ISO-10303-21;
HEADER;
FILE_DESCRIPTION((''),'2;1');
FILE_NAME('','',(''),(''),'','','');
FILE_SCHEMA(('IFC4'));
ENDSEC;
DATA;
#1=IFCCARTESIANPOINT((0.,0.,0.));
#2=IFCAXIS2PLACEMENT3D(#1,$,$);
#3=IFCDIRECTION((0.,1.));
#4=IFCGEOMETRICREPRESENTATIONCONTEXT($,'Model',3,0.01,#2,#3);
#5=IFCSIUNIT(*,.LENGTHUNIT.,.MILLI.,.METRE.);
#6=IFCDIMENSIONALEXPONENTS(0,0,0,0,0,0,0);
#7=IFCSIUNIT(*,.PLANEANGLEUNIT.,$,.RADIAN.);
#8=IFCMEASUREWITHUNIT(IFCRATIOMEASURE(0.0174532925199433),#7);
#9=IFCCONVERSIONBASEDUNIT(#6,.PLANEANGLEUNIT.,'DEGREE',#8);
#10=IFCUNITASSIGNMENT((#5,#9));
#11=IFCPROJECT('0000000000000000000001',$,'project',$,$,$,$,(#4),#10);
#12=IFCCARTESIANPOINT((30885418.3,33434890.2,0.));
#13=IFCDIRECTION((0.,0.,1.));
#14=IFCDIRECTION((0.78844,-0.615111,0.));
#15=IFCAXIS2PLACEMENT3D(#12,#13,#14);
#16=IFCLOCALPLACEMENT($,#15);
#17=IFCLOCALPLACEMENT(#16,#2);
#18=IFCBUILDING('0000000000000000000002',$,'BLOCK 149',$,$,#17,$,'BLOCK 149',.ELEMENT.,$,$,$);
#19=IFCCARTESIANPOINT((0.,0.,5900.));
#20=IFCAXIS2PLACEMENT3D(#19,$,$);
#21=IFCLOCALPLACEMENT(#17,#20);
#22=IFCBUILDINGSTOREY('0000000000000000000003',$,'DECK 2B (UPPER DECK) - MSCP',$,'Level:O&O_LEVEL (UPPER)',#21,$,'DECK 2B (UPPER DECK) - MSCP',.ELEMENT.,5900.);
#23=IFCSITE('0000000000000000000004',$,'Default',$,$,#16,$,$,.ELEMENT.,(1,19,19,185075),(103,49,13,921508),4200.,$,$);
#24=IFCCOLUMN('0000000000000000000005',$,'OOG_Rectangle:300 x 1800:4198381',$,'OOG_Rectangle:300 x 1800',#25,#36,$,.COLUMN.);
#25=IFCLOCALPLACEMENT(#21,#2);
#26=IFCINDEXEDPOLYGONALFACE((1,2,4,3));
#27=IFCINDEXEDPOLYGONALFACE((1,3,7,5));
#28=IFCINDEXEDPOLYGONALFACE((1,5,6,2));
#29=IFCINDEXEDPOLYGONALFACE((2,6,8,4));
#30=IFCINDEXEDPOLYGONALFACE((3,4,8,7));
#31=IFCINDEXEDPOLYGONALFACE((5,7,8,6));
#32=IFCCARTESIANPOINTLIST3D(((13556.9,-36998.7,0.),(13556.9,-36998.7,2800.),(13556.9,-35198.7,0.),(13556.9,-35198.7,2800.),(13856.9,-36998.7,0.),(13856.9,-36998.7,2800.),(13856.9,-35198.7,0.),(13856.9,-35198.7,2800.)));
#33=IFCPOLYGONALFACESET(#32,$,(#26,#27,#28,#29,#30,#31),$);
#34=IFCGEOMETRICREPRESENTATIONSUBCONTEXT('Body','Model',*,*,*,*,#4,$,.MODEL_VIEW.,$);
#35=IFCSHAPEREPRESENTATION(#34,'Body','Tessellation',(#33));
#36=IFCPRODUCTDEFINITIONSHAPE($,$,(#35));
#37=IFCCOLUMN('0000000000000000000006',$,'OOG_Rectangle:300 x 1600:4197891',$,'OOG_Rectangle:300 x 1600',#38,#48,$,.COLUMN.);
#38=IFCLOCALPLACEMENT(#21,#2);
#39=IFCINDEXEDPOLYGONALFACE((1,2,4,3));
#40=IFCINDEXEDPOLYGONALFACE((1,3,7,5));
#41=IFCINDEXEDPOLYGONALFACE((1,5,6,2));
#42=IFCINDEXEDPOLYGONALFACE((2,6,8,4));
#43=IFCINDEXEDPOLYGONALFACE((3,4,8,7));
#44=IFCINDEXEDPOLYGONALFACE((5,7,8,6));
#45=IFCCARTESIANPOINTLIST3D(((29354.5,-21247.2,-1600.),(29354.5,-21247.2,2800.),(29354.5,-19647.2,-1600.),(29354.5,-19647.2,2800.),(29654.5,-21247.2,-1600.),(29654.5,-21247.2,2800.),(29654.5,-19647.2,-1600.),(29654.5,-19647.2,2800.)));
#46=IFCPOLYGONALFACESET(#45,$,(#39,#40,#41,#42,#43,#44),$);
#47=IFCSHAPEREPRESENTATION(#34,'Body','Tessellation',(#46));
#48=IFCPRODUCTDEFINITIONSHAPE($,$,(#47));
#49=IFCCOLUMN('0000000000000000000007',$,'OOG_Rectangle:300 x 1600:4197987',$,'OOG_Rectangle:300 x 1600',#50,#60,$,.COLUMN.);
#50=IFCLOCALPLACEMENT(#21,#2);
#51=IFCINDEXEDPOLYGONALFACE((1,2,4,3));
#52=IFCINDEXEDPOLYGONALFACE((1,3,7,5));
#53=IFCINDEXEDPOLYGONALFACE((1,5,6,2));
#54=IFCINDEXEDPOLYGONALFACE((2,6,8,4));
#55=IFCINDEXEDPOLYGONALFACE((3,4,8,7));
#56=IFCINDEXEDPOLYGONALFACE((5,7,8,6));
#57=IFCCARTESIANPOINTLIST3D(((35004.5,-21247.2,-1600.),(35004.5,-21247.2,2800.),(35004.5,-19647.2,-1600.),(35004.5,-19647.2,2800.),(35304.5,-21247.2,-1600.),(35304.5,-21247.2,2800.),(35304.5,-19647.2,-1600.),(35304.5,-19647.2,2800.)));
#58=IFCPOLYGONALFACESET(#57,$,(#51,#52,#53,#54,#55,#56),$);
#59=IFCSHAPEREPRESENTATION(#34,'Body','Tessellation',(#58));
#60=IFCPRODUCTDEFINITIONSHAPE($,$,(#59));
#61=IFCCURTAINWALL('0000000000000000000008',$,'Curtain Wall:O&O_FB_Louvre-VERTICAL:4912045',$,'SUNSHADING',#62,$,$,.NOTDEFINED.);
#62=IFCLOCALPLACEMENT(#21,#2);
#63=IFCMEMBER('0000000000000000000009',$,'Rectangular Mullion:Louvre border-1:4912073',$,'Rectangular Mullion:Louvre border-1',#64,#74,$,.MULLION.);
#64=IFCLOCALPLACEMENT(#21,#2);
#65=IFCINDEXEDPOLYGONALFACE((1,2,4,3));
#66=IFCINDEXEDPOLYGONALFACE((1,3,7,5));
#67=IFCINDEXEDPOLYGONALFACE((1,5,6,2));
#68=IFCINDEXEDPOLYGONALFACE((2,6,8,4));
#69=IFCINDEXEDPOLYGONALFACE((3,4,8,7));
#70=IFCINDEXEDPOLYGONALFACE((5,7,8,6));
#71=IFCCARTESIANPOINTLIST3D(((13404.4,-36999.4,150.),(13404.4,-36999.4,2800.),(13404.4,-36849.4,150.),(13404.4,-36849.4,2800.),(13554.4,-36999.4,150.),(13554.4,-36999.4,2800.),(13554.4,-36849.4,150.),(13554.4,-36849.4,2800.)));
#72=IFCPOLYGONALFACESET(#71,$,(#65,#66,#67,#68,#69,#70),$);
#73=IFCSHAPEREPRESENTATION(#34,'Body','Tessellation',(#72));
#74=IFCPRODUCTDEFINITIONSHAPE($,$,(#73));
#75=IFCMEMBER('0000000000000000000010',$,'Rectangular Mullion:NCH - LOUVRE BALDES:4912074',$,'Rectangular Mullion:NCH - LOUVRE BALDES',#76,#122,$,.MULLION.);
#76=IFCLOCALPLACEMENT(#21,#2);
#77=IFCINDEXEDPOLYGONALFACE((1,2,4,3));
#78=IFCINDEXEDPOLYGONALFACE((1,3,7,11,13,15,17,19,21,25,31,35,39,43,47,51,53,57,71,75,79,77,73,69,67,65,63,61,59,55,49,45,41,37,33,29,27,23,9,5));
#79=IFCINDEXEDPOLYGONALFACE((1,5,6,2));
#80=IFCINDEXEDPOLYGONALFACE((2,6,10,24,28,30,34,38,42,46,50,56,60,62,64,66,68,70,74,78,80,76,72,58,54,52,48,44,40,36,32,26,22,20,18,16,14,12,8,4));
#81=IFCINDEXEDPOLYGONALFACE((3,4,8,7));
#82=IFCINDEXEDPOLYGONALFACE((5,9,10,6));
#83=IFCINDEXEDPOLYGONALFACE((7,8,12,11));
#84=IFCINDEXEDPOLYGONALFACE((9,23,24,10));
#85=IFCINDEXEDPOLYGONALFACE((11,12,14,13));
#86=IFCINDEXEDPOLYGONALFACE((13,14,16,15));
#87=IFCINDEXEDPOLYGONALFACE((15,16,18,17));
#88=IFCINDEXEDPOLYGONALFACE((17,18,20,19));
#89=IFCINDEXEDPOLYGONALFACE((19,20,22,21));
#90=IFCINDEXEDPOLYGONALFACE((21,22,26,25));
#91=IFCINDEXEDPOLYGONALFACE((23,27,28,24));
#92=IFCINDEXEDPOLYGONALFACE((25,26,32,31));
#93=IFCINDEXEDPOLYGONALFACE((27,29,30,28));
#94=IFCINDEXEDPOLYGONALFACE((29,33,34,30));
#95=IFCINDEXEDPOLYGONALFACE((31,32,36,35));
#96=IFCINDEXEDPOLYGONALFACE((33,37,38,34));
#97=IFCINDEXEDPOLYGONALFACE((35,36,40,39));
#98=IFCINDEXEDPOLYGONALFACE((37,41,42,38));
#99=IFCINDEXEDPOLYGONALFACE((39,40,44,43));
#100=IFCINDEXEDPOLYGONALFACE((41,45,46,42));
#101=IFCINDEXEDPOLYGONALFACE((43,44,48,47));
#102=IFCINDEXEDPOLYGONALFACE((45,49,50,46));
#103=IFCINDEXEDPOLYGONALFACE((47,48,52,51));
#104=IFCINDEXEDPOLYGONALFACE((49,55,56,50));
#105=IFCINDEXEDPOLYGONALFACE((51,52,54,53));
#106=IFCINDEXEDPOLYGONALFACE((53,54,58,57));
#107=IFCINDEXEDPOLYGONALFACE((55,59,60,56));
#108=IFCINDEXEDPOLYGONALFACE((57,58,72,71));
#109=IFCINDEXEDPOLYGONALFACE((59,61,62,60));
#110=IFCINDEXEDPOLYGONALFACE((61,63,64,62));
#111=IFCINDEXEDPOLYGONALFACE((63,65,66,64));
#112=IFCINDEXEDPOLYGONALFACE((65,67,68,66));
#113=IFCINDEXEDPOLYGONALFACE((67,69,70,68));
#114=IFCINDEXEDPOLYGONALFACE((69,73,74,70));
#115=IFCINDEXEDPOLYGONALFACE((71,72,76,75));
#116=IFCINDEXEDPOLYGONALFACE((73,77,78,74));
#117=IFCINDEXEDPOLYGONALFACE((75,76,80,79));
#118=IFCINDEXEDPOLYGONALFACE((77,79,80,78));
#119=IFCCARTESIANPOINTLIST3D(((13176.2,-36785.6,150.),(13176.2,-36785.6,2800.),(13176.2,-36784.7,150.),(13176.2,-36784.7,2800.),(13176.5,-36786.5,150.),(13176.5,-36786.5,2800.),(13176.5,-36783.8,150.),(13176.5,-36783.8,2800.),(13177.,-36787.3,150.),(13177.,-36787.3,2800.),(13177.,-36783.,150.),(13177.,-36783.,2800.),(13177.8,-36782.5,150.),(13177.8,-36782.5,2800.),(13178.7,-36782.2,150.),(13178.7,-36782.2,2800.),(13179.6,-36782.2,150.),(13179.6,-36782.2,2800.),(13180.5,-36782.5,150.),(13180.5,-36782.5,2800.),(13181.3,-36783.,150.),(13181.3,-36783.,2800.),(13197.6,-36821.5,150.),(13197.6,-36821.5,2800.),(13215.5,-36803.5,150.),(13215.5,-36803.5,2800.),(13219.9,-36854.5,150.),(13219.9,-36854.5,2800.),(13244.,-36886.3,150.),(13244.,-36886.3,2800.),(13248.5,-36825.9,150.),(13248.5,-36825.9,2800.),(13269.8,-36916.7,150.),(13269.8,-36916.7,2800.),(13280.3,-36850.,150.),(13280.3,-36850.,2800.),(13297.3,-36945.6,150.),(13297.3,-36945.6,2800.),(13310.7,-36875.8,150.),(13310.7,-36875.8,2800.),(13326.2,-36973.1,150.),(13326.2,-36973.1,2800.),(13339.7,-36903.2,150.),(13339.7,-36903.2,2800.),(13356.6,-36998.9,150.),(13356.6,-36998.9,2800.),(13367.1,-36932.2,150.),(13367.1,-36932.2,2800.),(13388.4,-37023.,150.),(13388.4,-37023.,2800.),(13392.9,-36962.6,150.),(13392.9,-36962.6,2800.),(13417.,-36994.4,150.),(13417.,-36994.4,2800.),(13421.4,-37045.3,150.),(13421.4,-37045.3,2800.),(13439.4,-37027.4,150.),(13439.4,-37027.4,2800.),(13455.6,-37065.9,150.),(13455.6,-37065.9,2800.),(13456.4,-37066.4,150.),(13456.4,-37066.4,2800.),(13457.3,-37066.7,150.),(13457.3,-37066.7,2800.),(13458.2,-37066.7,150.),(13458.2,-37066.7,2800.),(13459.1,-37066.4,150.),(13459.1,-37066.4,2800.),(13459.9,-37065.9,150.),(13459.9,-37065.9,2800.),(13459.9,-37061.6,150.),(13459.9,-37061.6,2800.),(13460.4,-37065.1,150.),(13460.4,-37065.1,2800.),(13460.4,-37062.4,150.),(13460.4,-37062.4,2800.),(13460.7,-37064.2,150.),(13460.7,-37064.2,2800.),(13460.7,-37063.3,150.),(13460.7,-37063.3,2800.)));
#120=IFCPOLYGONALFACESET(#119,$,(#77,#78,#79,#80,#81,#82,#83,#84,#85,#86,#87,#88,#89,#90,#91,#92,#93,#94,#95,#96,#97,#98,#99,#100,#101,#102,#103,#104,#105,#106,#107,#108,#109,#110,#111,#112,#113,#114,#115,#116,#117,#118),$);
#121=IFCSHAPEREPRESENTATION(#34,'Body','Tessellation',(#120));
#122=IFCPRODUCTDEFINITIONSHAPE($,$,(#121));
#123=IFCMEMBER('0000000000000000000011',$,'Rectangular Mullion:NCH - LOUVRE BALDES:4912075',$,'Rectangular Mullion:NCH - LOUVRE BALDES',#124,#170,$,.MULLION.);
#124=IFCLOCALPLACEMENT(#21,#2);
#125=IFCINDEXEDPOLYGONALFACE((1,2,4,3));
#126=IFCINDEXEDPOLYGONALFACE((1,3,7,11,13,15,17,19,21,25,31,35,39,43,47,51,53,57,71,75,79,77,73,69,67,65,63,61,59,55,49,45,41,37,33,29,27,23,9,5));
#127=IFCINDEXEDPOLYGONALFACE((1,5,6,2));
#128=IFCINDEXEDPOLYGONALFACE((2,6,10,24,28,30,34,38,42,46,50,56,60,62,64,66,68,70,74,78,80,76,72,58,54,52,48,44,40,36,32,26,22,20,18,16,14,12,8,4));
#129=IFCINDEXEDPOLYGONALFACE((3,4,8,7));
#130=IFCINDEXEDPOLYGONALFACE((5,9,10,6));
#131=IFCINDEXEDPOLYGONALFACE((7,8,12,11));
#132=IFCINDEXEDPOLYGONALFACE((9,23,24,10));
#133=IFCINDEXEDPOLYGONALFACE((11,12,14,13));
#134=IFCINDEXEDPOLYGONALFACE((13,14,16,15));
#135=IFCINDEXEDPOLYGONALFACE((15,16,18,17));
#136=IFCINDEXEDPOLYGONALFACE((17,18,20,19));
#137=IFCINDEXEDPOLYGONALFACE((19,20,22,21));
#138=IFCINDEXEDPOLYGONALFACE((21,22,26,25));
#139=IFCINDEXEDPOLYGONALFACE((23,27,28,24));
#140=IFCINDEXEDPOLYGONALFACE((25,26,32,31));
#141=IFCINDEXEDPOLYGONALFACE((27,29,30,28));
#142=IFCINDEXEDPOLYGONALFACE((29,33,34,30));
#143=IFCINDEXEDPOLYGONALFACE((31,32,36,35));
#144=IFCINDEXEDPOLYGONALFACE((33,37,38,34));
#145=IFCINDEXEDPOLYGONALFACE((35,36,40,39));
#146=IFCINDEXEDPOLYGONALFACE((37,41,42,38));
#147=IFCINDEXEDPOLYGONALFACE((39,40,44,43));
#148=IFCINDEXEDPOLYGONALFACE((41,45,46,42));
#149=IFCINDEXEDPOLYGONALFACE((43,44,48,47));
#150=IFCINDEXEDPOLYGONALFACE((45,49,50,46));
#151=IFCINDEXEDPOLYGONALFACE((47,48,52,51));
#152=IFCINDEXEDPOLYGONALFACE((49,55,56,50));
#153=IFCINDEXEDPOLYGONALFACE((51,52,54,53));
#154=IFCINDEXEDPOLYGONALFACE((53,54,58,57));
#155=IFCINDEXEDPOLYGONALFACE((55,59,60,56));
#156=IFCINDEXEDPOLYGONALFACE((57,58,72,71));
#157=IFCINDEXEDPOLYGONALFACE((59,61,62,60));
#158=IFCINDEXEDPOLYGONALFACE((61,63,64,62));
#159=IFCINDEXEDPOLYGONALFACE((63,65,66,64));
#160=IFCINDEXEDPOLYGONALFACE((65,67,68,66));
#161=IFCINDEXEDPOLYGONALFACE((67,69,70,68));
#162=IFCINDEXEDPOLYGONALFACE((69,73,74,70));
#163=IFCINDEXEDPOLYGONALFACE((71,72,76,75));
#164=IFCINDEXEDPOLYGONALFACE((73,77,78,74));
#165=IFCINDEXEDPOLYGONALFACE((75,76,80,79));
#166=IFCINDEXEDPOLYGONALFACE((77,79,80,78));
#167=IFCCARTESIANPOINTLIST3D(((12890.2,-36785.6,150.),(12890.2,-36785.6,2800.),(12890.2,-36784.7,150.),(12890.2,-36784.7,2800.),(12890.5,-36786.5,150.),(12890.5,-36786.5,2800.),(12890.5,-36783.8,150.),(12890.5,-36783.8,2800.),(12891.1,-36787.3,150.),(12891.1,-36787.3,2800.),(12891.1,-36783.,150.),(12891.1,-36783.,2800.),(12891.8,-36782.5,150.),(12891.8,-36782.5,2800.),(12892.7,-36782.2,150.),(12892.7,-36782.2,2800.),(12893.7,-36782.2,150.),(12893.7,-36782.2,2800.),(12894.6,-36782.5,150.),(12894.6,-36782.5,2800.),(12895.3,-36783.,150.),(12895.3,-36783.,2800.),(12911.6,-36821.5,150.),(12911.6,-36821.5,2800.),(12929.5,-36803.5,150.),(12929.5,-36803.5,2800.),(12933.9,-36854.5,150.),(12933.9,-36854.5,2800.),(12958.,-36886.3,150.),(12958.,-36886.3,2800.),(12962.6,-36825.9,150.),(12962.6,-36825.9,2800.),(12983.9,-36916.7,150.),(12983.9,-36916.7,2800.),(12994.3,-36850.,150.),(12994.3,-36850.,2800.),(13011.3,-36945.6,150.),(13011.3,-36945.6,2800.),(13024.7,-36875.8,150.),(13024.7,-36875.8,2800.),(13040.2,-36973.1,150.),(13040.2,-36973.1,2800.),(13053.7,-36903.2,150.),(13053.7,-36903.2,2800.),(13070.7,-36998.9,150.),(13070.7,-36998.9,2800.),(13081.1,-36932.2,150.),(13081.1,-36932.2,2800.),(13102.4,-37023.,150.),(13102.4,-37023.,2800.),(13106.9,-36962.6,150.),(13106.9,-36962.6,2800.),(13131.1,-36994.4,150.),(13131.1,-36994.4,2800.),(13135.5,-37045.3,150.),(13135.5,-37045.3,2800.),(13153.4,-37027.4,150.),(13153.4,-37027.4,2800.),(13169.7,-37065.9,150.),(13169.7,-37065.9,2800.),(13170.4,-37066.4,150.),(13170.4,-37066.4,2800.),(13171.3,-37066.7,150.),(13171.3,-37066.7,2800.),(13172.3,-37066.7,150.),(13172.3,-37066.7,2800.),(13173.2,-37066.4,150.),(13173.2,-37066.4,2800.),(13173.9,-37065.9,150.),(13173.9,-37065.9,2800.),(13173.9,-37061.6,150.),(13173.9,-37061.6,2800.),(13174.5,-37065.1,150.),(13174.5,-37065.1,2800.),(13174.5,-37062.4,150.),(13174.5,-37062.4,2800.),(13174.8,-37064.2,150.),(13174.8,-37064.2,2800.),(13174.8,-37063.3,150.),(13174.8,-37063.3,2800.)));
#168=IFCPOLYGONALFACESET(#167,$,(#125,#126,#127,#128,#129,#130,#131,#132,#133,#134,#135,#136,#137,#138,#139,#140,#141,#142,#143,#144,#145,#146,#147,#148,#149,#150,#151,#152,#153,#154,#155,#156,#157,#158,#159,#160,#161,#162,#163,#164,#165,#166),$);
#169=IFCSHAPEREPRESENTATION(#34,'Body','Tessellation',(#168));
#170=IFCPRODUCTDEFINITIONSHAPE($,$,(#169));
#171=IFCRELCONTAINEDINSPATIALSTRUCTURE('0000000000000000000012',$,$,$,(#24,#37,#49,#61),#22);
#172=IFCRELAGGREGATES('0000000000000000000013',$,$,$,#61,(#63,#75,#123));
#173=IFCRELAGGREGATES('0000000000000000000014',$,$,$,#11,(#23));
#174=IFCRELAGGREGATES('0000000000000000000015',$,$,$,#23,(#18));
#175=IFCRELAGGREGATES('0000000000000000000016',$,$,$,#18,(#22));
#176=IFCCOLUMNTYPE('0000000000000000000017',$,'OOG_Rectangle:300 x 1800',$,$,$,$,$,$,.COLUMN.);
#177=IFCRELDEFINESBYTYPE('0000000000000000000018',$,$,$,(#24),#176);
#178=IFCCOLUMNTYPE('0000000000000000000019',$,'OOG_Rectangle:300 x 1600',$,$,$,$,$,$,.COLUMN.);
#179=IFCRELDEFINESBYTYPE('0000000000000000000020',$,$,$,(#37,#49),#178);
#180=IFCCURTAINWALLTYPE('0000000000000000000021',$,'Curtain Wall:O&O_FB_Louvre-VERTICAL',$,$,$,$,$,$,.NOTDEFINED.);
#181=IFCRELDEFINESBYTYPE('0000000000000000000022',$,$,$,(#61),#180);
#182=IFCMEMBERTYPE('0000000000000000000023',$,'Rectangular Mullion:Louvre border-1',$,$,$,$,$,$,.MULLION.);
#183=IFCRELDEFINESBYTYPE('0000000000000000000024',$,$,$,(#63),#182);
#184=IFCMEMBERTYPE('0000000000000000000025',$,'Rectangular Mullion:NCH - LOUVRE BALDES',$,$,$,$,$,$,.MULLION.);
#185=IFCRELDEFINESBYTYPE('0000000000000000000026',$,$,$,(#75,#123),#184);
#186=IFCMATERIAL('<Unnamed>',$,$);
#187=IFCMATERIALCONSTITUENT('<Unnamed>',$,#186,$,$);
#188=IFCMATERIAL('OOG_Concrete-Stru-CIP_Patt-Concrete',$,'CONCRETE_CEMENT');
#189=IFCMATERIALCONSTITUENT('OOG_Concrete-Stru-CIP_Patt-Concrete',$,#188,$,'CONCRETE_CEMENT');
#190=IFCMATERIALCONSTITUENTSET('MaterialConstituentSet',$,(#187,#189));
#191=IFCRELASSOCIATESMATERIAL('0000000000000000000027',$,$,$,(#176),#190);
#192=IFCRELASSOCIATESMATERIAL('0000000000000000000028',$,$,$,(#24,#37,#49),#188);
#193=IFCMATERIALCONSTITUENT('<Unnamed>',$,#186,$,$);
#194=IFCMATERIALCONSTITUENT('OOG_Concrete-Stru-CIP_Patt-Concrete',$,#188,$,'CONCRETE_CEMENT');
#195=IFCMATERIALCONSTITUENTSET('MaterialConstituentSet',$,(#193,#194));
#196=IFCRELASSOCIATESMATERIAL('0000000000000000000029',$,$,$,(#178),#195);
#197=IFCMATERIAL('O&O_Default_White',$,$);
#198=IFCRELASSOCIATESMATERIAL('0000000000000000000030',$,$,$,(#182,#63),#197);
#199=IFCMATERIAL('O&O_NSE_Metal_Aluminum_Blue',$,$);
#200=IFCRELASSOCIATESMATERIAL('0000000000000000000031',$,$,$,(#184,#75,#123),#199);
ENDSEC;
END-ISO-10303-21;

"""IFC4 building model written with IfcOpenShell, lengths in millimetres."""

from ifc_helpers import new_model, entity, si_unit, converted_unit, direction, frame, origin, place, context, subcontext, project, spatial, indexed_curve, outline, extrude, source, transform, mapped, material, constituent, constituent_set, type_object, type_shapes, element, aggregate, save


model = new_model("IFC4")

# Units and contexts
model_context = context("Model", 3, precision=0.01, world=origin(), true_north=direction((0.0, 1.0)))
body_context = subcontext(model_context, "Body", "Model", "MODEL_VIEW")
ifc_project = project(units=[si_unit("LENGTHUNIT", "METRE", prefix="MILLI"), converted_unit("PLANEANGLEUNIT", "DEGREE", entity("IfcRatioMeasure", 0.0174532925199433), si_unit("PLANEANGLEUNIT", "RADIAN"), dimensions=[0, 0, 0, 0, 0, 0, 0])], contexts=[model_context])

# Site, building, storey
site_placement = place(None, frame((30885418.3, 33434890.2, 0.0), z_axis=(0.0, 0.0, 1.0), x_axis=(0.78844, -0.615111, 0.0)))
site = spatial("IfcSite", under=ifc_project, at=site_placement, Name="Default", CompositionType="ELEMENT", RefLatitude=(1, 19, 19, 185075), RefLongitude=(103, 49, 13, 921508), RefElevation=4200.0)
building_placement = place(site_placement, origin())
building = spatial("IfcBuilding", under=site, at=building_placement, Name="BLOCK 149", LongName="BLOCK 149", CompositionType="ELEMENT")
storey_placement = place(building_placement, frame((0.0, 0.0, 5900.0)))
storey = spatial("IfcBuildingStorey", under=building, at=storey_placement, Name="DECK 2B (UPPER DECK) - MSCP", ObjectType="Level:O&O_LEVEL (UPPER)", LongName="DECK 2B (UPPER DECK) - MSCP", CompositionType="ELEMENT", Elevation=5900.0)

# Columns
ifc_material_1 = material(Name="OOG_Concrete-Stru-CIP_Patt-Concrete", Category="CONCRETE_CEMENT")
ifc_material_2 = material(Name="<Unnamed>")
ifc_constituent_1 = constituent(ifc_material_2, Name="<Unnamed>")
ifc_constituent_2 = constituent(ifc_material_1, Name="OOG_Concrete-Stru-CIP_Patt-Concrete", Category="CONCRETE_CEMENT")
ifc_constituent_set_1 = constituent_set(constituents=[ifc_constituent_1, ifc_constituent_2], Name="MaterialConstituentSet")
column_type_1 = type_object("IfcColumnType", Name="OOG_Rectangle:300 x 1800", PredefinedType="COLUMN", material=ifc_constituent_set_1)
shared_shape_1 = source(origin(), body_context, "Body", "SweptSolid", [
    extrude(outline(indexed_curve([(-900.0, -150.0), (900.0, -150.0), (900.0, 150.0), (-900.0, 150.0), (-900.0, -150.0)], self_intersect=False)), frame((0.0, 0.0, 5900.0), z_axis=(0.0, 0.0, 1.0), x_axis=(0.0, -1.0, 0.0)), (0.0, 0.0, 1.0), 2800.0),
])
type_shapes(column_type_1, [shared_shape_1])
column_placement = place(storey_placement, frame((13706.9, -36098.7, -5900.0)))
element("IfcColumn", 1, at=column_placement, inside=storey, type_object=column_type_1, material=ifc_material_1, Name="OOG_Rectangle:300 x 1800:4198381", ObjectType="OOG_Rectangle:300 x 1800", PredefinedType="COLUMN", context=body_context, shape_type="MappedRepresentation", body=[
    mapped(shared_shape_1, transform((0.0, 0.0, 0.0), scale=1.0)),
])
ifc_constituent_3 = constituent(ifc_material_2, Name="<Unnamed>")
ifc_constituent_4 = constituent(ifc_material_1, Name="OOG_Concrete-Stru-CIP_Patt-Concrete", Category="CONCRETE_CEMENT")
ifc_constituent_set_2 = constituent_set(constituents=[ifc_constituent_3, ifc_constituent_4], Name="MaterialConstituentSet")
column_type_2 = type_object("IfcColumnType", Name="OOG_Rectangle:300 x 1600", PredefinedType="COLUMN", material=ifc_constituent_set_2)
shared_shape_2 = source(origin(), body_context, "Body", "SweptSolid", [
    extrude(outline(indexed_curve([(-800.0, -150.0), (800.0, -150.0), (800.0, 150.0), (-800.0, 150.0), (-800.0, -150.0)], self_intersect=False)), frame((0.0, 0.0, 4300.0), z_axis=(0.0, 0.0, 1.0), x_axis=(0.0, -1.0, 0.0)), (0.0, 0.0, 1.0), 4400.0),
])
type_shapes(column_type_2, [shared_shape_2])
for number, where, name in (
    (2, (29504.5, -20447.2, -5900.0), "OOG_Rectangle:300 x 1600:4197891"),
    (3, (35154.5, -20447.2, -5900.0), "OOG_Rectangle:300 x 1600:4197987"),
):
    element("IfcColumn", number, at=place(storey_placement, frame(where)), inside=storey, type_object=column_type_2, material=ifc_material_1, Name=name, ObjectType="OOG_Rectangle:300 x 1600", PredefinedType="COLUMN", context=body_context, shape_type="MappedRepresentation", body=[
        mapped(shared_shape_2, transform((0.0, 0.0, 0.0), scale=1.0)),
    ])

# Curtain wall, members
curtain_wall_type = type_object("IfcCurtainWallType", Name="Curtain Wall:O&O_FB_Louvre-VERTICAL", PredefinedType="NOTDEFINED")
curtain_wall_placement = place(storey_placement, frame((0.0, 0.0, -5900.0)))
curtain_wall = element("IfcCurtainWall", 4, at=curtain_wall_placement, inside=storey, type_object=curtain_wall_type, Name="Curtain Wall:O&O_FB_Louvre-VERTICAL:4912045", ObjectType="SUNSHADING", PredefinedType="NOTDEFINED")
ifc_material_3 = material(Name="O&O_Default_White")
member_type_1 = type_object("IfcMemberType", Name="Rectangular Mullion:Louvre border-1", PredefinedType="MULLION", material=ifc_material_3)
shared_shape_3 = source(origin(), body_context, "Body", "SweptSolid", [
    extrude(outline(indexed_curve([(-75.0, -75.0), (75.0, -75.0), (75.0, 75.0), (-75.0, 75.0), (-75.0, -75.0)], self_intersect=False)), frame((-75.0, 0.0, -2650.0), z_axis=(0.0, 0.0, 1.0), x_axis=(0.0, -1.0, 0.0)), (0.0, 0.0, 1.0), 2650.0),
])
type_shapes(member_type_1, [shared_shape_3])
placement = place(building_placement, origin())
member_1_placement = place(placement, frame((13554.4, -36924.4, 8700.0)))
member_1 = element("IfcMember", 5, at=member_1_placement, type_object=member_type_1, material=ifc_material_3, Name="Rectangular Mullion:Louvre border-1:4912073", ObjectType="Rectangular Mullion:Louvre border-1", PredefinedType="MULLION", context=body_context, shape_type="MappedRepresentation", body=[
    mapped(shared_shape_3, transform((0.0, 0.0, 0.0), scale=1.0)),
])
ifc_material_4 = material(Name="O&O_NSE_Metal_Aluminum_Blue")
member_type_2 = type_object("IfcMemberType", Name="Rectangular Mullion:NCH - LOUVRE BALDES", PredefinedType="MULLION", material=ifc_material_4)
shared_shape_4 = source(origin(), body_context, "Body", "SweptSolid", [
    extrude(outline(indexed_curve([(55.9, -188.9), (54.8, -149.1), (51.6, -109.3), (46.1, -69.8), (38.6, -30.6), (28.9, 8.1), (17.1, 46.2), (3.3, 83.6), (-12.6, 120.2), (-30.4, 155.9), (-50.1, 190.5), (-50.5, 191.4), (-51.1, 192.1), (-52.0, 192.5), (-52.9, 192.7), (-53.8, 192.6), (-54.7, 192.2), (-55.4, 191.6), (-55.8, 190.8), (-56.0, 189.9), (-55.9, 188.9), (-54.8, 149.1), (-51.6, 109.3), (-46.1, 69.8), (-38.6, 30.6), (-28.9, -8.1), (-17.1, -46.2), (-3.3, -83.6), (12.6, -120.2), (30.4, -155.9), (50.1, -190.5), (50.5, -191.4), (51.1, -192.1), (52.0, -192.5), (52.9, -192.7), (53.8, -192.6), (54.7, -192.2), (55.4, -191.6), (55.8, -190.8), (56.0, -189.9), (55.9, -188.9)], self_intersect=False)), frame((0.0, 0.0, -2650.0), z_axis=(0.0, 0.0, 1.0), x_axis=(0.490779, -0.871284, 0.0)), (0.0, 0.0, 1.0), 2650.0),
])
type_shapes(member_type_2, [shared_shape_4])
member_2_placement = place(placement, frame((13318.5, -36924.4, 6050.0), z_axis=(0.0, 0.0, -1.0), x_axis=(-1.0, 0.0, 0.0)))
member_2 = element("IfcMember", 6, at=member_2_placement, type_object=member_type_2, material=ifc_material_4, Name="Rectangular Mullion:NCH - LOUVRE BALDES:4912074", ObjectType="Rectangular Mullion:NCH - LOUVRE BALDES", PredefinedType="MULLION", context=body_context, shape_type="MappedRepresentation", body=[
    mapped(shared_shape_4, transform((0.0, 0.0, 0.0), scale=1.0)),
])
member_3_placement = place(placement, frame((13032.5, -36924.4, 6050.0), z_axis=(0.0, 0.0, -1.0), x_axis=(-1.0, 0.0, 0.0)))
member_3 = element("IfcMember", 7, at=member_3_placement, type_object=member_type_2, material=ifc_material_4, Name="Rectangular Mullion:NCH - LOUVRE BALDES:4912075", ObjectType="Rectangular Mullion:NCH - LOUVRE BALDES", PredefinedType="MULLION", context=body_context, shape_type="MappedRepresentation", body=[
    mapped(shared_shape_4, transform((0.0, 0.0, 0.0), scale=1.0)),
])
aggregate(curtain_wall, [member_1, member_2, member_3])

save(model, "model.ifc")
